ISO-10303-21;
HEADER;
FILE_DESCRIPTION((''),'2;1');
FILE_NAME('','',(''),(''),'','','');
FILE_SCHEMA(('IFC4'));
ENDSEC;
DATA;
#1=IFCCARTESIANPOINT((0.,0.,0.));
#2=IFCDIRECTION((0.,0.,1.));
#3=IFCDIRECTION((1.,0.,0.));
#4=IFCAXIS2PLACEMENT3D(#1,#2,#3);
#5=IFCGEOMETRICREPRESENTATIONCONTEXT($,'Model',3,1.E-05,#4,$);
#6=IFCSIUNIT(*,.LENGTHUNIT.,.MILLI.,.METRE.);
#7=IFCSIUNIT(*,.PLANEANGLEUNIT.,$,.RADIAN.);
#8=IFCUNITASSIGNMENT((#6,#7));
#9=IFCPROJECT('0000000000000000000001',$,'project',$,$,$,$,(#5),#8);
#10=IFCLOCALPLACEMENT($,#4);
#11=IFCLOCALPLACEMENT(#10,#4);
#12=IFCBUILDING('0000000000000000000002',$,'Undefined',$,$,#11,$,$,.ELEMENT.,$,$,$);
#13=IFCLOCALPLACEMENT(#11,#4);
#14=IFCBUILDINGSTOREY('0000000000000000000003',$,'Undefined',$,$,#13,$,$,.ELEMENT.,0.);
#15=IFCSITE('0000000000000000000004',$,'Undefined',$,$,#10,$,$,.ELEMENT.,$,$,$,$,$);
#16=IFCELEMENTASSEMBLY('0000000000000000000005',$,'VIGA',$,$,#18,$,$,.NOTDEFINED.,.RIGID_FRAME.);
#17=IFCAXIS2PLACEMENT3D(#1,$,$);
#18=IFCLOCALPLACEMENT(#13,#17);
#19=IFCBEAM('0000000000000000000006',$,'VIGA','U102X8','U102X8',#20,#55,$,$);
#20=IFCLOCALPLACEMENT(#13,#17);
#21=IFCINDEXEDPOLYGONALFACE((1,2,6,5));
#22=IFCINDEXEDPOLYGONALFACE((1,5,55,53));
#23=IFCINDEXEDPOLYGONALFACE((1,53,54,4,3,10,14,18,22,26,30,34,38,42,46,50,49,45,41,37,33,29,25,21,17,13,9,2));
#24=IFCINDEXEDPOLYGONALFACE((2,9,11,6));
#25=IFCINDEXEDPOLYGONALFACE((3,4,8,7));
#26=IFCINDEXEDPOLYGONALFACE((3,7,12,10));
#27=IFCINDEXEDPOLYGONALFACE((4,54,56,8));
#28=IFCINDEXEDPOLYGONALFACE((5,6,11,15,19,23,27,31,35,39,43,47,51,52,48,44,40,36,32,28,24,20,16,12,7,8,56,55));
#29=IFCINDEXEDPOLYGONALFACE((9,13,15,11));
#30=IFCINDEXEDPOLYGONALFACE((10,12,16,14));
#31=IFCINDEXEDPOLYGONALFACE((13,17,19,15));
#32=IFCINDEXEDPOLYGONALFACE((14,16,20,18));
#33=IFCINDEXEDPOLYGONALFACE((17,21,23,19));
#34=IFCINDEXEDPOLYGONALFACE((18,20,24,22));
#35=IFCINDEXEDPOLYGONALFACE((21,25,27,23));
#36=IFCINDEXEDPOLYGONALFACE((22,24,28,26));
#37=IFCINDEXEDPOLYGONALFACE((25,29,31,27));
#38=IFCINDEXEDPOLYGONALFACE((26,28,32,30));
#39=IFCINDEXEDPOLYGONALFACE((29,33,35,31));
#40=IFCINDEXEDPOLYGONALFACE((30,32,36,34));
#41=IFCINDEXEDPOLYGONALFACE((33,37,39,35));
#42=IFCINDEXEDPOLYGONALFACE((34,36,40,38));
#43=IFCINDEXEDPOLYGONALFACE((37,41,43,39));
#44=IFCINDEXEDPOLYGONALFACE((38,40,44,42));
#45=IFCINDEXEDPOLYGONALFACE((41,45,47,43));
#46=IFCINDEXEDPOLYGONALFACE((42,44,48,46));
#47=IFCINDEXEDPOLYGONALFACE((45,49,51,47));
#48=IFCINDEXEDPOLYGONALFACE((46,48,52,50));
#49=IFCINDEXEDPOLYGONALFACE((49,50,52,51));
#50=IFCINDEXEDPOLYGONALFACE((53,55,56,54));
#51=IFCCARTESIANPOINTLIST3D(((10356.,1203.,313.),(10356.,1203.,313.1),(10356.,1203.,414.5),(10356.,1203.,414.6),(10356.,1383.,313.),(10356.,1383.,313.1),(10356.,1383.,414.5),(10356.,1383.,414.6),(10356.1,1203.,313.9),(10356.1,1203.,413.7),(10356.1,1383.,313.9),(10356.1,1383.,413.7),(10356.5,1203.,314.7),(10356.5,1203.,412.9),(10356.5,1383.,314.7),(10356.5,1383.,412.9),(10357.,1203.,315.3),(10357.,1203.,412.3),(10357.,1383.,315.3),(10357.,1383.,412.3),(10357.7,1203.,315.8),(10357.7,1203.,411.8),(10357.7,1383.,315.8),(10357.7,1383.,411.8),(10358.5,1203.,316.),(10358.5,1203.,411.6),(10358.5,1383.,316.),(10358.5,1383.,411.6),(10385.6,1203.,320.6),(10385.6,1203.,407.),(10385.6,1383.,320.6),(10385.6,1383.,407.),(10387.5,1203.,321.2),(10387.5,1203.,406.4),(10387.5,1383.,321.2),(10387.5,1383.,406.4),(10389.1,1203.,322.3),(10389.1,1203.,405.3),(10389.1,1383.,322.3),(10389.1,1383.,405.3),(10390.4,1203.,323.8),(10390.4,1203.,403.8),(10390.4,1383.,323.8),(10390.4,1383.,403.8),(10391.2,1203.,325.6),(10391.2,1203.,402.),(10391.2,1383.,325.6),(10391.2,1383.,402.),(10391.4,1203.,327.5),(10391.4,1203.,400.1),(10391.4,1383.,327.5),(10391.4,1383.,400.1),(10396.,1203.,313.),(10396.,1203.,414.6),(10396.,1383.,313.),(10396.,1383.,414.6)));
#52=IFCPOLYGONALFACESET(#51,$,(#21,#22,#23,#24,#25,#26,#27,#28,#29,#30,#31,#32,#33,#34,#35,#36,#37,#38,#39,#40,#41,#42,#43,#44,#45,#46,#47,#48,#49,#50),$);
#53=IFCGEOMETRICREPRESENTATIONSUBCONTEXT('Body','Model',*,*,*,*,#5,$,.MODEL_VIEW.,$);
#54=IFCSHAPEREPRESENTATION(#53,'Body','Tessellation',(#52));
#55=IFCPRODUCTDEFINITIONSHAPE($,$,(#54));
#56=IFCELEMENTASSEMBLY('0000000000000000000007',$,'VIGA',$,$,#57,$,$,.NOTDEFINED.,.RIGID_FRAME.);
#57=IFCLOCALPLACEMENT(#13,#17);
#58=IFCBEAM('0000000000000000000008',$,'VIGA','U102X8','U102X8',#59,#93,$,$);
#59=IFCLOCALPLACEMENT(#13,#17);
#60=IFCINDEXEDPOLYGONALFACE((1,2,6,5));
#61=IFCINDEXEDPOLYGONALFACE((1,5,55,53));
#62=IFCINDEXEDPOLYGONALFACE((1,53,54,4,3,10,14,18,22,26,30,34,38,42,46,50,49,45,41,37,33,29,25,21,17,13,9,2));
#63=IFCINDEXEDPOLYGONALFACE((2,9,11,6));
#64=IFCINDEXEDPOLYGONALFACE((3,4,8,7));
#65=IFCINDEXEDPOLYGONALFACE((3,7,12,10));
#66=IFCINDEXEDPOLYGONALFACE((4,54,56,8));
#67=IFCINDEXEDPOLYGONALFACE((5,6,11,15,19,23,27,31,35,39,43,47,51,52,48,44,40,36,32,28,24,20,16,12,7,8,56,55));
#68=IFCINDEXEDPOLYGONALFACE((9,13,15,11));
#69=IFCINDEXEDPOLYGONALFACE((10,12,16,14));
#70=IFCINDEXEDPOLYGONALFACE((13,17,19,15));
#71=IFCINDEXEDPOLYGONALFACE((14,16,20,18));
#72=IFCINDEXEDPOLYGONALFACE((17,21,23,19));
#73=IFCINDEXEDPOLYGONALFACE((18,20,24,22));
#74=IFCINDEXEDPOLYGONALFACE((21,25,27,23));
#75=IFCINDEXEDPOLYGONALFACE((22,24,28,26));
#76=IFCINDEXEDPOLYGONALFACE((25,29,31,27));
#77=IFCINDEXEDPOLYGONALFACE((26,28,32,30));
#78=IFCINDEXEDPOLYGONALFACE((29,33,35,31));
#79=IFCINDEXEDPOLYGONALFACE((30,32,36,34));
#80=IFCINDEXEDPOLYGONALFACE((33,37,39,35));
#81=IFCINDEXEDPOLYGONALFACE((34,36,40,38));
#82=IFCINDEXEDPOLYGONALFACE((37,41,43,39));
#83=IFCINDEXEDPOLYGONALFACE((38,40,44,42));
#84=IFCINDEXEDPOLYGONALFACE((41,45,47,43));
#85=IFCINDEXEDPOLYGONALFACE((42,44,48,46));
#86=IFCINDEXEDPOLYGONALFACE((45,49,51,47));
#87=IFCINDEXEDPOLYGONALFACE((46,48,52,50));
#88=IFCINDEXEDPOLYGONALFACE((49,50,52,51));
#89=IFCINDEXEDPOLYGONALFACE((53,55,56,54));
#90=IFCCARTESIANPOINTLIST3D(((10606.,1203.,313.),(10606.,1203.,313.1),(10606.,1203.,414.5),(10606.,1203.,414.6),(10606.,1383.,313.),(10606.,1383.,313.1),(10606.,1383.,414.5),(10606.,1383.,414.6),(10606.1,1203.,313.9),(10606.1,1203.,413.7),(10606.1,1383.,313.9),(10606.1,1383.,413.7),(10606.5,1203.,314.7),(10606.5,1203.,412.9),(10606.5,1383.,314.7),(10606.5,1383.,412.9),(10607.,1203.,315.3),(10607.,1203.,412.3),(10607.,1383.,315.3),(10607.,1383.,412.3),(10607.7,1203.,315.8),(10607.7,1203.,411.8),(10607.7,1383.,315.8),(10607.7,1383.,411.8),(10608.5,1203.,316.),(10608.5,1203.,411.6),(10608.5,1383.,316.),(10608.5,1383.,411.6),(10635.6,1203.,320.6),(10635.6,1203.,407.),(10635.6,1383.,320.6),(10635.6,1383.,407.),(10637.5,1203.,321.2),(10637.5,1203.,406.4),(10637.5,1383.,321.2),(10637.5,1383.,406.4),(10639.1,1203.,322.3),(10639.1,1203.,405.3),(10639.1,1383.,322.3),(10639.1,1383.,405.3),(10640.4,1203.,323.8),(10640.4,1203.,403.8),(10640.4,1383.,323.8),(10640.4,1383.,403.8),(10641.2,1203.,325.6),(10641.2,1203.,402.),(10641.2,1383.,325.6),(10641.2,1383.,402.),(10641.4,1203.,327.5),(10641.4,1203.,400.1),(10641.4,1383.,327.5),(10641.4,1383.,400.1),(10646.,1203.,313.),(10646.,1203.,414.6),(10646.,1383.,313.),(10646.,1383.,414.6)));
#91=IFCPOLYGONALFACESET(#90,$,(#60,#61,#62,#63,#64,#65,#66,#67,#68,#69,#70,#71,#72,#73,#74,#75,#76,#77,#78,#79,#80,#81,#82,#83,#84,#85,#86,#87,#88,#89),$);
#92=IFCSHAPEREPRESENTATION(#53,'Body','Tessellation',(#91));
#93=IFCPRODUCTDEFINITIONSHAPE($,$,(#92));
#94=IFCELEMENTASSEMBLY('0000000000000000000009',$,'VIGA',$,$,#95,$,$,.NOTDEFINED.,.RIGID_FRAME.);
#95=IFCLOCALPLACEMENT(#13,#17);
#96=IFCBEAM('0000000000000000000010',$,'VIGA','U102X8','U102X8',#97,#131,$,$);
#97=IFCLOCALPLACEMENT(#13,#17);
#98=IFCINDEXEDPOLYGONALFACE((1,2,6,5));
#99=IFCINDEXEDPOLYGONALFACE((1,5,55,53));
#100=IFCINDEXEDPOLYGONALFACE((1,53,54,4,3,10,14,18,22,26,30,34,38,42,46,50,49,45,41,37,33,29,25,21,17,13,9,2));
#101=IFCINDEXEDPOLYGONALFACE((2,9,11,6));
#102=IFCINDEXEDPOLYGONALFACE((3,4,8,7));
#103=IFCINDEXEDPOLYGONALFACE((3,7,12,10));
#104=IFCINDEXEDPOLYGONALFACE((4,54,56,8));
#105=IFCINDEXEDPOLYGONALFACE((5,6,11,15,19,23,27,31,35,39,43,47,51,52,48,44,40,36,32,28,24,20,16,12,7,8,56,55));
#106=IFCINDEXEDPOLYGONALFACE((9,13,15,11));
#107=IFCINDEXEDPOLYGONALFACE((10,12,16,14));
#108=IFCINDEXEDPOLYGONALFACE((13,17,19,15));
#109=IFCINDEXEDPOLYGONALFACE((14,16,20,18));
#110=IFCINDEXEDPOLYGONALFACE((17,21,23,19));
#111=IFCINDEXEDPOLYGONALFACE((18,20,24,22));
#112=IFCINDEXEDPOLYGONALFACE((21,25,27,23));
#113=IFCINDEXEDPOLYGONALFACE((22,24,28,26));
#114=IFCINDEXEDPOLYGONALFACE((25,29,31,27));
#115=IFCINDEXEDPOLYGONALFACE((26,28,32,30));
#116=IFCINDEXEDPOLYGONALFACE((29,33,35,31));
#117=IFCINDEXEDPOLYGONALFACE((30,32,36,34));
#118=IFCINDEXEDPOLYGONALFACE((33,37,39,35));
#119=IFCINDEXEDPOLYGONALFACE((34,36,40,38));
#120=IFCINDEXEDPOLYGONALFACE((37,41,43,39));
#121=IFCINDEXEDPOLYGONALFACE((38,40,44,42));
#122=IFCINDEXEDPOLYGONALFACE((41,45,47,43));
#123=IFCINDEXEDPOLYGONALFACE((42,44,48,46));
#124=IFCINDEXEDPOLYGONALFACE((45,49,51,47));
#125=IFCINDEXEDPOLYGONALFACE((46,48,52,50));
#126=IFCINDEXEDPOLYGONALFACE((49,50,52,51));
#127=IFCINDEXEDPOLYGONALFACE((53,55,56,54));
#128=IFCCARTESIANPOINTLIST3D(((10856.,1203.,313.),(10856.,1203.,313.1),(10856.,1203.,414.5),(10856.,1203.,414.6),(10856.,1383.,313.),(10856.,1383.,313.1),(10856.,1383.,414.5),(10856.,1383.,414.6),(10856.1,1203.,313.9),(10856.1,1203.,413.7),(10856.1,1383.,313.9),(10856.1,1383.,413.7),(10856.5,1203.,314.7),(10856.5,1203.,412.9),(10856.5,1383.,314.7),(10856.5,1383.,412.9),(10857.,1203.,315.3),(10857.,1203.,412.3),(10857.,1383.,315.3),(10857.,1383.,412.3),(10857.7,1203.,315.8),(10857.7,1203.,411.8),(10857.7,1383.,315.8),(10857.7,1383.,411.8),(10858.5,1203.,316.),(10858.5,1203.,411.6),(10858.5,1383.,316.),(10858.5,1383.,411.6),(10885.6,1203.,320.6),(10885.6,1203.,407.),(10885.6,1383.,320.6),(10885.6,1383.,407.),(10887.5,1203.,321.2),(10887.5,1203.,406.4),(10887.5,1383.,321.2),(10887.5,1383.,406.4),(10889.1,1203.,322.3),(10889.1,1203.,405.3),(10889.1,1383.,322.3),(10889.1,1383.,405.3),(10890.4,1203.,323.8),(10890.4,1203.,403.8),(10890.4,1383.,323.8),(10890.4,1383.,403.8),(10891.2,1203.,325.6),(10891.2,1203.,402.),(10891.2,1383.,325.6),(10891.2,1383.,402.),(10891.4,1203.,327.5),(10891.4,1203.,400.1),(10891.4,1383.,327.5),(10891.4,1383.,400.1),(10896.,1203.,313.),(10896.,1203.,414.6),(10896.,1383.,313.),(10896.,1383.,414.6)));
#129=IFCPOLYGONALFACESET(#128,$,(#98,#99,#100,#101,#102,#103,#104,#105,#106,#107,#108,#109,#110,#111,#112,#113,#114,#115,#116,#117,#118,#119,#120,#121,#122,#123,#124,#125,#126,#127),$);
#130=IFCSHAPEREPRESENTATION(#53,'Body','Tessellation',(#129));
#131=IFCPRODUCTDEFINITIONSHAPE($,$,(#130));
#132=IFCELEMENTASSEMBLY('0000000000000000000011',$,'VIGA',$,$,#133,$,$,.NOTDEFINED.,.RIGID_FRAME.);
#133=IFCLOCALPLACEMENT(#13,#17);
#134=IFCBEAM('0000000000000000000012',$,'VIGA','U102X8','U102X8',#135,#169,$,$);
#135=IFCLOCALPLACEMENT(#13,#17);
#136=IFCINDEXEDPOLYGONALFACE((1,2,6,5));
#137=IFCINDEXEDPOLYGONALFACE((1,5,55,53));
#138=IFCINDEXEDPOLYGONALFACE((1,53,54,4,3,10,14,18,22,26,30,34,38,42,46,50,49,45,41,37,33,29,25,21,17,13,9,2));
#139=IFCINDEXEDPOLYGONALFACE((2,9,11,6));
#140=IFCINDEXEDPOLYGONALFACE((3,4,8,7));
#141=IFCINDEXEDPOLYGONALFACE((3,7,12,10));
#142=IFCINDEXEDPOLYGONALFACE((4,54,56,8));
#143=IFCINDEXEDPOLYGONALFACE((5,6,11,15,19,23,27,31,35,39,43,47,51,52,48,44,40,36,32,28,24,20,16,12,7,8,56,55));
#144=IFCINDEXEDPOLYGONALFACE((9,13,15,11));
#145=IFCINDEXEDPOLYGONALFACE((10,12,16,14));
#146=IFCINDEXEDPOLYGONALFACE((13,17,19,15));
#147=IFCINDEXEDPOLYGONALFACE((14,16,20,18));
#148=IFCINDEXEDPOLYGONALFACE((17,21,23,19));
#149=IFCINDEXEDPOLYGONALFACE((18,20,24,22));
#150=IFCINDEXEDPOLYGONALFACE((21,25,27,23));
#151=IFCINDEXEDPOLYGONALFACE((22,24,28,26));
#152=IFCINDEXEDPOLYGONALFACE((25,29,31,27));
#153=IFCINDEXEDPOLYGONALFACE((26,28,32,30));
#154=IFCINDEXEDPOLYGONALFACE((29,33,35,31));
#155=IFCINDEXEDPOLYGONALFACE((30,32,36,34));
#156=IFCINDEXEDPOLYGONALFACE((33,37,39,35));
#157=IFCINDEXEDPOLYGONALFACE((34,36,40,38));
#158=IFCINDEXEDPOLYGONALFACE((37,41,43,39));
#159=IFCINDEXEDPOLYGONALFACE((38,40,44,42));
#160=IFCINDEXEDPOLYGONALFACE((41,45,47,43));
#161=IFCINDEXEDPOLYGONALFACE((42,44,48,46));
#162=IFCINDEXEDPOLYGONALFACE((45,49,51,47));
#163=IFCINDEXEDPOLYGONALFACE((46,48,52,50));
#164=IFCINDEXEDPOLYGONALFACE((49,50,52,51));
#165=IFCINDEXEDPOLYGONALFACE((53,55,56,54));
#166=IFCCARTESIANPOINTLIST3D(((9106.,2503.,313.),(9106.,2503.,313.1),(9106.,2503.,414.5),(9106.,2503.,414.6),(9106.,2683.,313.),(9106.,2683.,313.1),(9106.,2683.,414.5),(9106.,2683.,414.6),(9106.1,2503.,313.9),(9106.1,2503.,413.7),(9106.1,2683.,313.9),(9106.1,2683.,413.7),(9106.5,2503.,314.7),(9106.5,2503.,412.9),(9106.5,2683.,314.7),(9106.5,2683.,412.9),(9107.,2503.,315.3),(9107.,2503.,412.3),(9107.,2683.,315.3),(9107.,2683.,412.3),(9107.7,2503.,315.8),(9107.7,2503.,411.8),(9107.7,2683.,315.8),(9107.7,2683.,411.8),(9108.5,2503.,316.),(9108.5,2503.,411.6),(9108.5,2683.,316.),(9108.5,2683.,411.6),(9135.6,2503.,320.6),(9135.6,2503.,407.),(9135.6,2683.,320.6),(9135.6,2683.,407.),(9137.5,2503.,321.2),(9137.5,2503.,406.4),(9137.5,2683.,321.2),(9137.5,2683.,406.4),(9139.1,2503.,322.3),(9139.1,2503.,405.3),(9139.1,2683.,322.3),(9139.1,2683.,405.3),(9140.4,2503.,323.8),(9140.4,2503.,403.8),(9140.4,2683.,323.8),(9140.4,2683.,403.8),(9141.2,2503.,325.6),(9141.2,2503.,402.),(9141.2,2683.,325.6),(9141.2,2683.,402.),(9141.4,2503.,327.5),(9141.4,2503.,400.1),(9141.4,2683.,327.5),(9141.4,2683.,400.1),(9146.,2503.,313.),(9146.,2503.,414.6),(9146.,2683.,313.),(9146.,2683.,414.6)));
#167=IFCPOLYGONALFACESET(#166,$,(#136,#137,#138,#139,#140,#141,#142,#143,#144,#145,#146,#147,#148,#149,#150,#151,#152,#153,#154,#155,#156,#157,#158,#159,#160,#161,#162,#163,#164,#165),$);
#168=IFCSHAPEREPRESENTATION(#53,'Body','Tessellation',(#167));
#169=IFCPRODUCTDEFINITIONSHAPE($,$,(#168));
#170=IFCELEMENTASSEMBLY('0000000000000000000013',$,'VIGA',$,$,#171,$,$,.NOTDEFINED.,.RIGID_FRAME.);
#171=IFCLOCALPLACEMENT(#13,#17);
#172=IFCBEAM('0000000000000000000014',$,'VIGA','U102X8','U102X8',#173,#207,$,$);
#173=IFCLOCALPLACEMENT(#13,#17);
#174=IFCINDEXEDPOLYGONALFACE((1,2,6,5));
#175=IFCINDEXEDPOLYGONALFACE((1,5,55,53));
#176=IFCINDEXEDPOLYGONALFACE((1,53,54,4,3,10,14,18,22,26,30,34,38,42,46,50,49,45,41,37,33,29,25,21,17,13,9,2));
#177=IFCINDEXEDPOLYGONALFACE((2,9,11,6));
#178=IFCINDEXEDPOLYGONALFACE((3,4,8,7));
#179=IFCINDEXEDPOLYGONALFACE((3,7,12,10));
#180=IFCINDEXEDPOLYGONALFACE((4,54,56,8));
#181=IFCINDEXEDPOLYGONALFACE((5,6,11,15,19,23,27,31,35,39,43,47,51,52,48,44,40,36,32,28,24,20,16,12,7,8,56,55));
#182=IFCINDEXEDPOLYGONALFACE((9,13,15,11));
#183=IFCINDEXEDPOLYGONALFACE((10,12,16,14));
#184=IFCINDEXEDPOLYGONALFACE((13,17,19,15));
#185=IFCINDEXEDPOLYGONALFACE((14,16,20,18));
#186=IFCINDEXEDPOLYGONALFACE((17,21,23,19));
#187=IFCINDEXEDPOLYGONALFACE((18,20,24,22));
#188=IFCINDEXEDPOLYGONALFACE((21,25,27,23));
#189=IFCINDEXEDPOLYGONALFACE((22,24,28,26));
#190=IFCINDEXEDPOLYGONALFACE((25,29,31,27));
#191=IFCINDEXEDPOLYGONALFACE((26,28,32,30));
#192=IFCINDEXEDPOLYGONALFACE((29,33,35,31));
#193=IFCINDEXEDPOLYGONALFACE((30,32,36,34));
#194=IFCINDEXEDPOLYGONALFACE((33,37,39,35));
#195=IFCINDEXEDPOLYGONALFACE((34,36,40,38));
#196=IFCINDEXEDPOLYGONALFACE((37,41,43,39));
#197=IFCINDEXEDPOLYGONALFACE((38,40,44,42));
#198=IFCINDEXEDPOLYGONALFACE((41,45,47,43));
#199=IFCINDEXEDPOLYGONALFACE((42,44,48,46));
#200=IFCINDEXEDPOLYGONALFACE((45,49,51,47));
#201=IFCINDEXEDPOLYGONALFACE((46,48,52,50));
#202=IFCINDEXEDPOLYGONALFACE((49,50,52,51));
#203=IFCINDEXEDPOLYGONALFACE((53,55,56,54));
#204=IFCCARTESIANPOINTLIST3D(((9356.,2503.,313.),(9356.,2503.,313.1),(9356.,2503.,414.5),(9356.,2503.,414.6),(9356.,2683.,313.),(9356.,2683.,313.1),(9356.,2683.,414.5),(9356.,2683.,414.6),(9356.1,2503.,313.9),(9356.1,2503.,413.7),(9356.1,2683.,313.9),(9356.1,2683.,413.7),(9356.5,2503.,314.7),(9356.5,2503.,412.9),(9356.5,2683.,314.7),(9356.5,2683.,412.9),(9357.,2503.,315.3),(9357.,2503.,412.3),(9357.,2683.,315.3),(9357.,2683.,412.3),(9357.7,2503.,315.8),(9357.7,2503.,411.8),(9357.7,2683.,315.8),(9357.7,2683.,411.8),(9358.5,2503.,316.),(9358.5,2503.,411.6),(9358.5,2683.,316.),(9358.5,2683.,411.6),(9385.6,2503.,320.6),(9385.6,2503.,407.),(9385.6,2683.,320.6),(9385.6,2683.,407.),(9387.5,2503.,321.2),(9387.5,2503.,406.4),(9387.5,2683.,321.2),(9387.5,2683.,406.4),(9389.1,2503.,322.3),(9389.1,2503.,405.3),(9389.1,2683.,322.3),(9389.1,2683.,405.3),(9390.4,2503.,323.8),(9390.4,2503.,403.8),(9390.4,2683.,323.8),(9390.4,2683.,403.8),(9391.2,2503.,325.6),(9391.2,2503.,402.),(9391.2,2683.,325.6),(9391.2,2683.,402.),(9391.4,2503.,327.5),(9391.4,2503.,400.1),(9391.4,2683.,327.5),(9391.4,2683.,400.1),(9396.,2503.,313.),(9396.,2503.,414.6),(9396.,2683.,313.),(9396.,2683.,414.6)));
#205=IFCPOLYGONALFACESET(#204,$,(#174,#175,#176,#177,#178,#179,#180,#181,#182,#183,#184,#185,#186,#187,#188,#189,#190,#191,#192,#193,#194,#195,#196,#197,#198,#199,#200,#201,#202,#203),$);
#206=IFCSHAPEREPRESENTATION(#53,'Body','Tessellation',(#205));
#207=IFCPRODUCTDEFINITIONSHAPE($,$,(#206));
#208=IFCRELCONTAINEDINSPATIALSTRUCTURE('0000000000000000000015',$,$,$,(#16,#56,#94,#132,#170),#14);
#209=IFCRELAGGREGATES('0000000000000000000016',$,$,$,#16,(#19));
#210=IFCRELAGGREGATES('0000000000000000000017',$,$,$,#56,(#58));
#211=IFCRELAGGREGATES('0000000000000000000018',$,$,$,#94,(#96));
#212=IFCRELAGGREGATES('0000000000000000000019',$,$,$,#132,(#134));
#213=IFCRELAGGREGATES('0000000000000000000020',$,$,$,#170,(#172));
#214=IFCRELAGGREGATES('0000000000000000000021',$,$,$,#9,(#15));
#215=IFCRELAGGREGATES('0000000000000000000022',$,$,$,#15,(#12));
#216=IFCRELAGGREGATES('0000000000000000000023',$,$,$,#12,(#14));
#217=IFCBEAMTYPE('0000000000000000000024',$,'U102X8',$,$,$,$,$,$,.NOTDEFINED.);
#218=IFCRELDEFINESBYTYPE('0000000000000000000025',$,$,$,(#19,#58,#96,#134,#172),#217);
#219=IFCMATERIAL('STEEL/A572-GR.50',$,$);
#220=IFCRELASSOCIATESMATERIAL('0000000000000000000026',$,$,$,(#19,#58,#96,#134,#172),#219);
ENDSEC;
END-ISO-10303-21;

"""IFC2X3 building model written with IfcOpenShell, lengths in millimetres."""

from ifc_helpers import new_model, si_unit, frame, origin_with_axes, origin_2d_with_axis, place, context, subcontext, project, spatial, u_section, extrude, material, type_object, element, aggregate, save


model = new_model("IFC2X3")

# Units and contexts
model_context = context("Model", 3, precision=1e-05, world=origin_with_axes())
body_context = subcontext(model_context, "Body", "Model", "MODEL_VIEW")
ifc_project = project(units=[si_unit("LENGTHUNIT", "METRE", prefix="MILLI"), si_unit("PLANEANGLEUNIT", "RADIAN")], contexts=[model_context])

# Site, building, storey
site_placement = place(None, origin_with_axes())
site = spatial("IfcSite", under=ifc_project, at=site_placement, Name="Undefined", CompositionType="ELEMENT")
building_placement = place(site_placement, origin_with_axes())
building = spatial("IfcBuilding", under=site, at=building_placement, Name="Undefined", CompositionType="ELEMENT")
storey_placement = place(building_placement, origin_with_axes())
storey = spatial("IfcBuildingStorey", under=building, at=storey_placement, Name="Undefined", CompositionType="ELEMENT", Elevation=0.0)

# Element assemblies, beams
ifc_material_1 = material(Name="STEEL/A572-GR.50")
beam_type = type_object("IfcBeamType", Name="U102X8", PredefinedType="NOTDEFINED")
assembly_1_placement = place(storey_placement, origin_with_axes())
assembly_1 = element("IfcElementAssembly", 1, at=assembly_1_placement, inside=storey, Name="VIGA", AssemblyPlace="NOTDEFINED", PredefinedType="RIGID_FRAME")
beam_1_placement = place(assembly_1_placement, frame((10376.0, 1383.0, 363.8), z_axis=(0.0, 0.0, 1.0), x_axis=(0.0, -1.0, 0.0)))
beam_1 = element("IfcBeam", 2, at=beam_1_placement, type_object=beam_type, material=ifc_material_1, Name="VIGA", Description="U102X8", ObjectType="U102X8", context=body_context, shape_type="SweptSolid", body=[
    extrude(u_section(Depth=101.6, FlangeWidth=40.0, WebThickness=4.6, FlangeThickness=6.0, FilletRadius=7.0, EdgeRadius=3.0, FlangeSlope=0.16839, at=origin_2d_with_axis()), frame((180.0, 0.0, 0.0), z_axis=(-1.0, 0.0, 0.0), x_axis=(0.0, -1.0, 0.0)), (0.0, 0.0, 1.0), 180.0),
])
aggregate(assembly_1, [beam_1])
assembly_2_placement = place(storey_placement, origin_with_axes())
assembly_2 = element("IfcElementAssembly", 3, at=assembly_2_placement, inside=storey, Name="VIGA", AssemblyPlace="NOTDEFINED", PredefinedType="RIGID_FRAME")
beam_2_placement = place(assembly_2_placement, frame((10626.0, 1383.0, 363.8), z_axis=(0.0, 0.0, 1.0), x_axis=(0.0, -1.0, 0.0)))
beam_2 = element("IfcBeam", 4, at=beam_2_placement, type_object=beam_type, material=ifc_material_1, Name="VIGA", Description="U102X8", ObjectType="U102X8", context=body_context, shape_type="SweptSolid", body=[
    extrude(u_section(Depth=101.6, FlangeWidth=40.0, WebThickness=4.6, FlangeThickness=6.0, FilletRadius=7.0, EdgeRadius=3.0, FlangeSlope=0.16839, at=origin_2d_with_axis()), frame((180.0, 0.0, 0.0), z_axis=(-1.0, 0.0, 0.0), x_axis=(0.0, -1.0, 0.0)), (0.0, 0.0, 1.0), 180.0),
])
aggregate(assembly_2, [beam_2])
assembly_3_placement = place(storey_placement, origin_with_axes())
assembly_3 = element("IfcElementAssembly", 5, at=assembly_3_placement, inside=storey, Name="VIGA", AssemblyPlace="NOTDEFINED", PredefinedType="RIGID_FRAME")
beam_3_placement = place(assembly_3_placement, frame((10876.0, 1383.0, 363.8), z_axis=(0.0, 0.0, 1.0), x_axis=(0.0, -1.0, 0.0)))
beam_3 = element("IfcBeam", 6, at=beam_3_placement, type_object=beam_type, material=ifc_material_1, Name="VIGA", Description="U102X8", ObjectType="U102X8", context=body_context, shape_type="SweptSolid", body=[
    extrude(u_section(Depth=101.6, FlangeWidth=40.0, WebThickness=4.6, FlangeThickness=6.0, FilletRadius=7.0, EdgeRadius=3.0, FlangeSlope=0.16839, at=origin_2d_with_axis()), frame((180.0, 0.0, 0.0), z_axis=(-1.0, 0.0, 0.0), x_axis=(0.0, -1.0, 0.0)), (0.0, 0.0, 1.0), 180.0),
])
aggregate(assembly_3, [beam_3])
assembly_4_placement = place(storey_placement, origin_with_axes())
assembly_4 = element("IfcElementAssembly", 7, at=assembly_4_placement, inside=storey, Name="VIGA", AssemblyPlace="NOTDEFINED", PredefinedType="RIGID_FRAME")
beam_4_placement = place(assembly_4_placement, frame((9126.0, 2683.0, 363.8), z_axis=(0.0, 0.0, 1.0), x_axis=(0.0, -1.0, 0.0)))
beam_4 = element("IfcBeam", 8, at=beam_4_placement, type_object=beam_type, material=ifc_material_1, Name="VIGA", Description="U102X8", ObjectType="U102X8", context=body_context, shape_type="SweptSolid", body=[
    extrude(u_section(Depth=101.6, FlangeWidth=40.0, WebThickness=4.6, FlangeThickness=6.0, FilletRadius=7.0, EdgeRadius=3.0, FlangeSlope=0.16839, at=origin_2d_with_axis()), frame((180.0, 0.0, 0.0), z_axis=(-1.0, 0.0, 0.0), x_axis=(0.0, -1.0, 0.0)), (0.0, 0.0, 1.0), 180.0),
])
aggregate(assembly_4, [beam_4])
assembly_5_placement = place(storey_placement, origin_with_axes())
assembly_5 = element("IfcElementAssembly", 9, at=assembly_5_placement, inside=storey, Name="VIGA", AssemblyPlace="NOTDEFINED", PredefinedType="RIGID_FRAME")
beam_5_placement = place(assembly_5_placement, frame((9376.0, 2683.0, 363.8), z_axis=(0.0, 0.0, 1.0), x_axis=(0.0, -1.0, 0.0)))
beam_5 = element("IfcBeam", 10, at=beam_5_placement, type_object=beam_type, material=ifc_material_1, Name="VIGA", Description="U102X8", ObjectType="U102X8", context=body_context, shape_type="SweptSolid", body=[
    extrude(u_section(Depth=101.6, FlangeWidth=40.0, WebThickness=4.6, FlangeThickness=6.0, FilletRadius=7.0, EdgeRadius=3.0, FlangeSlope=0.16839, at=origin_2d_with_axis()), frame((180.0, 0.0, 0.0), z_axis=(-1.0, 0.0, 0.0), x_axis=(0.0, -1.0, 0.0)), (0.0, 0.0, 1.0), 180.0),
])
aggregate(assembly_5, [beam_5])

save(model, "model.ifc")
